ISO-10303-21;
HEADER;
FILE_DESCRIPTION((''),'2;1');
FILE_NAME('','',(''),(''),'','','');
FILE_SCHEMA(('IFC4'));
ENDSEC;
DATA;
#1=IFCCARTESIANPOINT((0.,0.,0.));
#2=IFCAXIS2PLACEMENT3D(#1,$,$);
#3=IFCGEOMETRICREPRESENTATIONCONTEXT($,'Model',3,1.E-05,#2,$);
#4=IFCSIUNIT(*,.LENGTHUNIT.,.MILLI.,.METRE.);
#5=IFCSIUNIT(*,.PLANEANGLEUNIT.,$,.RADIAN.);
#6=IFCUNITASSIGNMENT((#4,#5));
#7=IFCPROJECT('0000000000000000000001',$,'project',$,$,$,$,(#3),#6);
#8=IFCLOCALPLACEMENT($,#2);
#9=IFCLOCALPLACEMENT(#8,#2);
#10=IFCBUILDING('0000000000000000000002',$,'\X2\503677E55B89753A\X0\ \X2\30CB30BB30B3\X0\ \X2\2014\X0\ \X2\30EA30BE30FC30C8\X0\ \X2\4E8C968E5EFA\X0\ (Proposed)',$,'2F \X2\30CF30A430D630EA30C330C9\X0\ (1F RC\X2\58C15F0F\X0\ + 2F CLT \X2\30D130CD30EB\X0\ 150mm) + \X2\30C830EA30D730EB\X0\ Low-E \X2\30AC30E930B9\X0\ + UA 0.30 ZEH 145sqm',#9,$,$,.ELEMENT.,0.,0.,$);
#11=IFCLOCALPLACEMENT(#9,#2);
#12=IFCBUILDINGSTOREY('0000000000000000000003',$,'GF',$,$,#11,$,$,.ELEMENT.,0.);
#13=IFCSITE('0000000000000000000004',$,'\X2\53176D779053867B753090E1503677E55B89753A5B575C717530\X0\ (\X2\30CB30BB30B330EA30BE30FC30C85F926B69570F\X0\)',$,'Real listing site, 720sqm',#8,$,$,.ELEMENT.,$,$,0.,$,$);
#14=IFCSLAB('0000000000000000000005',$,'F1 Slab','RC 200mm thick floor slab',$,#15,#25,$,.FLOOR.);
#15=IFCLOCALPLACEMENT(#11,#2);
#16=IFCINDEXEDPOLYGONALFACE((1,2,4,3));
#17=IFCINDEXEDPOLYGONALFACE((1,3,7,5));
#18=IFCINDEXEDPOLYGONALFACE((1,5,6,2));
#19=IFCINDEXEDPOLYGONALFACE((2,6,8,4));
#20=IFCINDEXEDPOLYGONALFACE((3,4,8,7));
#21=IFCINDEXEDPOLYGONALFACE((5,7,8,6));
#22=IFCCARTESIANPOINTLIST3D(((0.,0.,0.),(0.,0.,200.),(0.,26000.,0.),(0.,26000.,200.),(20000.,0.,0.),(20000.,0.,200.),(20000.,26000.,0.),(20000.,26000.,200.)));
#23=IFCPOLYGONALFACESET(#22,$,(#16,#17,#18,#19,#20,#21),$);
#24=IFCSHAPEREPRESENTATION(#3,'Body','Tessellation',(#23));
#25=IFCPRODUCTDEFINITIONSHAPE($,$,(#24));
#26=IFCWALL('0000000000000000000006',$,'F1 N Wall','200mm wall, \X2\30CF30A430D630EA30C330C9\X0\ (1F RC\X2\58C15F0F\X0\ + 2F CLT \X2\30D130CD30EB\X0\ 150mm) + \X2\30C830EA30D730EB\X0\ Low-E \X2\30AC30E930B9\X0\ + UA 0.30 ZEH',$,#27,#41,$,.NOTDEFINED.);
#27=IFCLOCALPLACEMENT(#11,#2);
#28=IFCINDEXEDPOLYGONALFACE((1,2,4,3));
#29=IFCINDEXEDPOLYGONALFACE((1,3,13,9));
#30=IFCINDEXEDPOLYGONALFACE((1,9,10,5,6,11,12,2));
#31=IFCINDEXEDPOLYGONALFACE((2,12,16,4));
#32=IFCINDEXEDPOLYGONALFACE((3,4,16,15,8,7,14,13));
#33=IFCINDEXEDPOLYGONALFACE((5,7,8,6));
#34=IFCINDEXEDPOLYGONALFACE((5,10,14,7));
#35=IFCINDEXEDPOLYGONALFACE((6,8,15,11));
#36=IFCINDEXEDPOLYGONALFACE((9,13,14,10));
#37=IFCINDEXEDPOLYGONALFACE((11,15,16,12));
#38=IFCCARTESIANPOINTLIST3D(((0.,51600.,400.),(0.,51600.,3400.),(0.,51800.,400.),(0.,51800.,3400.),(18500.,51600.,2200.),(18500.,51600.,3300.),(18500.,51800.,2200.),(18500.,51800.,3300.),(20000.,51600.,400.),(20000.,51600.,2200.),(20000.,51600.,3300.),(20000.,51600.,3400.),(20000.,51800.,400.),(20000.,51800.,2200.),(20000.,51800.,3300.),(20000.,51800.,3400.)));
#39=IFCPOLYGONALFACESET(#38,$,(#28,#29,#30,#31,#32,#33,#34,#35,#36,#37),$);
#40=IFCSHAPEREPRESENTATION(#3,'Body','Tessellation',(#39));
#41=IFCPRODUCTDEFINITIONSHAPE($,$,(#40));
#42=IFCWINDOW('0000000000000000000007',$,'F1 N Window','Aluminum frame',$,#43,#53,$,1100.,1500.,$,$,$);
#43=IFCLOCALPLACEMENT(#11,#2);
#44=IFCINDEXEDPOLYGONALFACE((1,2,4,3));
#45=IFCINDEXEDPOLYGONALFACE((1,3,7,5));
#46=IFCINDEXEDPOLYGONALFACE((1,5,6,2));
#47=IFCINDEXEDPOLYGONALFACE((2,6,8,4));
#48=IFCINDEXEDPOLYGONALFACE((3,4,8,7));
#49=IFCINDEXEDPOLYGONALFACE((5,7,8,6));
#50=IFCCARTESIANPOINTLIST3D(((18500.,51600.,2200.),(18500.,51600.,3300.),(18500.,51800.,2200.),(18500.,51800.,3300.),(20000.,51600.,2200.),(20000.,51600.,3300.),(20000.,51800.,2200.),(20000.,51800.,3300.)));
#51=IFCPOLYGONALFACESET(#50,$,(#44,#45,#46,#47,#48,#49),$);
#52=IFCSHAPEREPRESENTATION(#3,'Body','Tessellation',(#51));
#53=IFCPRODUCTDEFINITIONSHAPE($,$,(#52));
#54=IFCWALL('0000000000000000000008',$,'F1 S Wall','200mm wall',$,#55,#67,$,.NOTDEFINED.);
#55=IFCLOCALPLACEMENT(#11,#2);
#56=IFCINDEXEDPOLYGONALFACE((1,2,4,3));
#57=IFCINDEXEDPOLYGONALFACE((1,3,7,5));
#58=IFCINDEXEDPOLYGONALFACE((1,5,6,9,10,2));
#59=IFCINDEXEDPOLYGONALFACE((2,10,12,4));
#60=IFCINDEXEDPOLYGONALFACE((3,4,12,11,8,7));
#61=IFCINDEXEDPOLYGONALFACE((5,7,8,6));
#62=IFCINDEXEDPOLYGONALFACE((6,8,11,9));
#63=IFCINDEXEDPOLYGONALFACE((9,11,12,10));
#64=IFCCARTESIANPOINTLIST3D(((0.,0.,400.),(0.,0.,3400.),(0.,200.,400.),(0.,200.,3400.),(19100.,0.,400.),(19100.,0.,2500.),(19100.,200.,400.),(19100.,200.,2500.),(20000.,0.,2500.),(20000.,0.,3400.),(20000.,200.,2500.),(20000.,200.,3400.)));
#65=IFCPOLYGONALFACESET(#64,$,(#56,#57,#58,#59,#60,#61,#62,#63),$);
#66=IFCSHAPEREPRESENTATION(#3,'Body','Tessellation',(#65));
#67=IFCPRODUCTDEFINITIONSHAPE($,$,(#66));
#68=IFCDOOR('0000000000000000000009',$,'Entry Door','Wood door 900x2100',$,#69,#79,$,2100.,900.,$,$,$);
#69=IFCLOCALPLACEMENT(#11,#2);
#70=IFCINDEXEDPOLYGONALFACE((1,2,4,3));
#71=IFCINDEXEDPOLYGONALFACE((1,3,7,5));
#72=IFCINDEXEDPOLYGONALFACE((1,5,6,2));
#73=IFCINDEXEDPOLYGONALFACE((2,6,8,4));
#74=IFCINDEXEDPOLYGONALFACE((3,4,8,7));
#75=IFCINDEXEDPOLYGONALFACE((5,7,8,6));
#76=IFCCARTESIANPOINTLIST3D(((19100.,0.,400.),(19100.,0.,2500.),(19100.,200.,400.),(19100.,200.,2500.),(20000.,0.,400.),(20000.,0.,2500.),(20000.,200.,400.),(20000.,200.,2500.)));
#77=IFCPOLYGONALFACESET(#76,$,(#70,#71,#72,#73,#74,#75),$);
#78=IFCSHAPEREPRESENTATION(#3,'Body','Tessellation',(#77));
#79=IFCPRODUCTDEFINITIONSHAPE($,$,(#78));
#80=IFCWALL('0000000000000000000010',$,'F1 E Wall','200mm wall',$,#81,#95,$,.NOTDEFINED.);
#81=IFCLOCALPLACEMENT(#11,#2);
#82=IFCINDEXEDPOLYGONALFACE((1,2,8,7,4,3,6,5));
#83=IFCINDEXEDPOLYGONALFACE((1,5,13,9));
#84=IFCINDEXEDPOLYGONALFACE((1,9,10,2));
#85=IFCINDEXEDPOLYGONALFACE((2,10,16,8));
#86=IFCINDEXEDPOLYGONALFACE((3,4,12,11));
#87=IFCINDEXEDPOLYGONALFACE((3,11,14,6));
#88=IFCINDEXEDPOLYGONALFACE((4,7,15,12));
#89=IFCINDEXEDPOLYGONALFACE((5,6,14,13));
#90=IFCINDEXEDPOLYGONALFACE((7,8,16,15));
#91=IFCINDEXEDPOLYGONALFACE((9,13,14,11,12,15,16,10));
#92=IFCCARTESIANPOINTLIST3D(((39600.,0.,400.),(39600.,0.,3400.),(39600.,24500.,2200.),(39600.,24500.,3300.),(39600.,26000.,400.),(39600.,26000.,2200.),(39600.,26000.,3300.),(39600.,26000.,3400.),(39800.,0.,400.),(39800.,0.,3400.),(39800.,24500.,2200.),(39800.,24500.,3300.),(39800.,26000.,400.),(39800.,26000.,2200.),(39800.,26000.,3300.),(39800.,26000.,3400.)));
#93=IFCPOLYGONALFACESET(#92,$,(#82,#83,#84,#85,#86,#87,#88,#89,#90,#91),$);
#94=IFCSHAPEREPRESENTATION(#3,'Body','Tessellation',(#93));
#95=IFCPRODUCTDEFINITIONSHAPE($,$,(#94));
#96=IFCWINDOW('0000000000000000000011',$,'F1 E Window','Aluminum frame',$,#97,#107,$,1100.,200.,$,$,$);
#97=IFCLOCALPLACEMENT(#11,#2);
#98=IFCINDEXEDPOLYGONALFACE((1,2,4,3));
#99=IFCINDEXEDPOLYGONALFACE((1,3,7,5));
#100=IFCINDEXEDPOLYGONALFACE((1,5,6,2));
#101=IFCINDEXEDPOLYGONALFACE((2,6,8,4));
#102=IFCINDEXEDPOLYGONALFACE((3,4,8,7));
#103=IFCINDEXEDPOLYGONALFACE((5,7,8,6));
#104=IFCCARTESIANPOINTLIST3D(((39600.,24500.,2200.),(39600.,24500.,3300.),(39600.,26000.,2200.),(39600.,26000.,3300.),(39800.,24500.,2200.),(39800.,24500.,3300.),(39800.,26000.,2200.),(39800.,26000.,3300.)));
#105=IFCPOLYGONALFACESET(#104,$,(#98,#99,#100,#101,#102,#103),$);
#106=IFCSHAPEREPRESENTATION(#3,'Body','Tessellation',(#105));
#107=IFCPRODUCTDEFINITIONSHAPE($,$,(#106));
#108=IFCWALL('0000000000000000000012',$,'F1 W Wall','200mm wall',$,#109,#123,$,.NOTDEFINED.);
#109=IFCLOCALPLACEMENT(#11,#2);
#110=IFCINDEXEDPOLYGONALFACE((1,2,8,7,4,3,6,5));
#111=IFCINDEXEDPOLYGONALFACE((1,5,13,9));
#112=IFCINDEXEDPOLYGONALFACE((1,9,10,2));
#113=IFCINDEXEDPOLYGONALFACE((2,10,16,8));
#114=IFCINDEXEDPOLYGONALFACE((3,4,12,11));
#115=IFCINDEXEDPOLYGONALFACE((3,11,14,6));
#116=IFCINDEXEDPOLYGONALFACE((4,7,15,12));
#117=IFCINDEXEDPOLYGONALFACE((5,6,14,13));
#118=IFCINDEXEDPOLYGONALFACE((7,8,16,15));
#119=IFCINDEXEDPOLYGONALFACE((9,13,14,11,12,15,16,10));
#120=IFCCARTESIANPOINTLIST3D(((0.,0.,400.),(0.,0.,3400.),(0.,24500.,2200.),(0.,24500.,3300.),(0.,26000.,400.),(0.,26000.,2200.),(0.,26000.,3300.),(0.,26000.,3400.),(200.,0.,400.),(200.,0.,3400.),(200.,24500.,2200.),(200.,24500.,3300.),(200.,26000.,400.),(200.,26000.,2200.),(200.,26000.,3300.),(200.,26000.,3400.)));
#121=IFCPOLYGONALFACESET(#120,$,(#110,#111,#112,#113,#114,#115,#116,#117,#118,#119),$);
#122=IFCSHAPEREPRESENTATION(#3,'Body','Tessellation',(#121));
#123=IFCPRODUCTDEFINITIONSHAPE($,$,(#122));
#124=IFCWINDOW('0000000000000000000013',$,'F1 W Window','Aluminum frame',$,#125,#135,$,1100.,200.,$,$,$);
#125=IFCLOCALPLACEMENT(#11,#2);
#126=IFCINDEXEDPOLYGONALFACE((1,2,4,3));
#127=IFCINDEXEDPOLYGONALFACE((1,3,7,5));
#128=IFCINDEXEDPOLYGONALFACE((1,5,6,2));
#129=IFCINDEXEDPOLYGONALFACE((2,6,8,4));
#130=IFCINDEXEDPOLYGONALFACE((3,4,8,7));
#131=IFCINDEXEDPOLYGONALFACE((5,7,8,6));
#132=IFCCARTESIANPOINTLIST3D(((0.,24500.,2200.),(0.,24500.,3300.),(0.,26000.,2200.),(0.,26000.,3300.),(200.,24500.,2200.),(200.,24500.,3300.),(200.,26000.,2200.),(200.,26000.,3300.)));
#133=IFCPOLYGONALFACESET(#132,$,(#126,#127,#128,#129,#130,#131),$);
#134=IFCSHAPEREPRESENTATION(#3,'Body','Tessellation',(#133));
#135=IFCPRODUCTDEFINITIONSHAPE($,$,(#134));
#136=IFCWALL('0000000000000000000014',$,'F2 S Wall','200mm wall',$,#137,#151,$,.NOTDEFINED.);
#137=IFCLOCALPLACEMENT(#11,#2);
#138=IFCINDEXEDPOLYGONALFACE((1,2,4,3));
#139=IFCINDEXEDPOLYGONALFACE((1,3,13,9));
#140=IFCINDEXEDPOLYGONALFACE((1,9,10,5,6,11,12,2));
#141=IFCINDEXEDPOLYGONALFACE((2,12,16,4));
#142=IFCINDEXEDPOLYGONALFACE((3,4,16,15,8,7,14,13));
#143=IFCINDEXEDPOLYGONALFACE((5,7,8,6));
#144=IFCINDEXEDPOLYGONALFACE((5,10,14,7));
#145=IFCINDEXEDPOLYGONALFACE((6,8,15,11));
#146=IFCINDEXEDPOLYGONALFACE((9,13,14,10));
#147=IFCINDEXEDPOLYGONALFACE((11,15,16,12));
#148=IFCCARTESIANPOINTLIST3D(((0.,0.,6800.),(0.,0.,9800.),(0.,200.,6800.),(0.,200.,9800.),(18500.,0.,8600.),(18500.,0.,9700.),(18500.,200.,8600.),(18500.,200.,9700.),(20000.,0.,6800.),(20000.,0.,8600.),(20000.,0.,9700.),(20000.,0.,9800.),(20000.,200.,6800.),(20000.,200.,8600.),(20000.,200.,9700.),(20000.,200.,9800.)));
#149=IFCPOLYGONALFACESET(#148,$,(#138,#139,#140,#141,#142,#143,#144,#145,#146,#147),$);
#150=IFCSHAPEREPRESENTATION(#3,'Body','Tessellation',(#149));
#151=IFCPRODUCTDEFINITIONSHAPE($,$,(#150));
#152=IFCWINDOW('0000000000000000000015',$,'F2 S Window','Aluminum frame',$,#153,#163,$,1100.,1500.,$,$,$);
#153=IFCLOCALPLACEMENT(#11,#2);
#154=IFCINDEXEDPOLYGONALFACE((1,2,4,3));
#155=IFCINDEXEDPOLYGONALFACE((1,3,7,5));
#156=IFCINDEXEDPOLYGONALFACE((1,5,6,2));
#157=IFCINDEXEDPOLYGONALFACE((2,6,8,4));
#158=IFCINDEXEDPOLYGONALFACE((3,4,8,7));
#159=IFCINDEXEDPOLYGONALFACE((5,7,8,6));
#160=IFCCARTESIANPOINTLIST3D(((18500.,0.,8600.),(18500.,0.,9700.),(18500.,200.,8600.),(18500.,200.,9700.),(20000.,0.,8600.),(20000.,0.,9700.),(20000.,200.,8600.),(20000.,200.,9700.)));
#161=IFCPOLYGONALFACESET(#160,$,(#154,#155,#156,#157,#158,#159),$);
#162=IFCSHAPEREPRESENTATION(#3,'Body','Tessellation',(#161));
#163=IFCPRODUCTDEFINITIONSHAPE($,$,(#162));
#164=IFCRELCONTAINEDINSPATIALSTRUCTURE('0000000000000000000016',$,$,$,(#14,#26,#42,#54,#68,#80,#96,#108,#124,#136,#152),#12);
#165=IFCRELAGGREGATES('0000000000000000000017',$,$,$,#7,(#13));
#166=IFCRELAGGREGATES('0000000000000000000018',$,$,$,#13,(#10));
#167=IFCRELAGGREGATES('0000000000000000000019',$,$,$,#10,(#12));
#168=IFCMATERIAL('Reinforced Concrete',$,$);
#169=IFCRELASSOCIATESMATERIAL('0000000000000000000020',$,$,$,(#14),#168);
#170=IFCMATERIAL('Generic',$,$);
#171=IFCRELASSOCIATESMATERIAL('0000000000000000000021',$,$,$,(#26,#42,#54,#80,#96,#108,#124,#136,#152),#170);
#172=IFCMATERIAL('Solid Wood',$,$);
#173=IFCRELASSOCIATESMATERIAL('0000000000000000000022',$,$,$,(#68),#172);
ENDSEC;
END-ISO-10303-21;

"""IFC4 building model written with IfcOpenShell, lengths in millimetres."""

from ifc_helpers import new_model, si_unit, frame, frame_2d, origin, place, context, project, spatial, rectangle, extrude, material, element, fill, save


model = new_model("IFC4")

# Units and contexts
model_context = context("Model", 3, precision=1e-05, world=origin())
ifc_project = project(units=[si_unit("LENGTHUNIT", "METRE", prefix="MILLI"), si_unit("PLANEANGLEUNIT", "RADIAN")], contexts=[model_context])

# Site, building, storey
site_placement = place(None, origin())
site = spatial("IfcSite", under=ifc_project, at=site_placement, Name="北海道虻田郡倶知安町字山田 (ニセコリゾート徒歩圏)", ObjectType="Real listing site, 720sqm", CompositionType="ELEMENT", RefElevation=0.0)
building_placement = place(site_placement, origin())
building = spatial("IfcBuilding", under=site, at=building_placement, Name="倶知安町 ニセコ — リゾート 二階建 (Proposed)", ObjectType="2F ハイブリッド (1F RC壁式 + 2F CLT パネル 150mm) + トリプル Low-E ガラス + UA 0.30 ZEH 145sqm", CompositionType="ELEMENT", ElevationOfRefHeight=0.0, ElevationOfTerrain=0.0)
storey_placement = place(building_placement, origin())
storey = spatial("IfcBuildingStorey", under=building, at=storey_placement, Name="GF", CompositionType="ELEMENT", Elevation=0.0)

# Slab
ifc_material_1 = material(Name="Reinforced Concrete")
slab_1_placement = place(storey_placement, origin())
element("IfcSlab", 1, at=slab_1_placement, inside=storey, material=ifc_material_1, Name="F1 Slab", Description="RC 200mm thick floor slab", PredefinedType="FLOOR", context=model_context, shape_type="SweptSolid", body=[
    extrude(rectangle(XDim=20000.0, YDim=26000.0, at=frame_2d((10000.0, 13000.0))), origin(), (0.0, 0.0, 1.0), 200.0),
])

# Wall, opening, window
ifc_material_2 = material(Name="Generic")
wall_1_placement = place(storey_placement, frame((0.0, 25800.0, 200.0)))
wall_1 = element("IfcWall", 2, at=wall_1_placement, inside=storey, material=ifc_material_2, Name="F1 N Wall", Description="200mm wall, ハイブリッド (1F RC壁式 + 2F CLT パネル 150mm) + トリプル Low-E ガラス + UA 0.30 ZEH", PredefinedType="NOTDEFINED", context=model_context, shape_type="SweptSolid", body=[
    extrude(rectangle(XDim=20000.0, YDim=200.0, at=frame_2d((10000.0, 100.0))), frame((0.0, 25800.0, 200.0)), (0.0, 0.0, 1.0), 3000.0),
])
opening_1_placement = place(storey_placement, frame((9250.0, 25800.0, 1100.0)))
opening_1 = element("IfcOpeningElement", 3, at=opening_1_placement, cuts=wall_1, PredefinedType="NOTDEFINED", context=model_context, shape_type="SweptSolid", body=[
    extrude(rectangle(XDim=1500.0, YDim=200.0, at=frame_2d((750.0, 100.0))), frame((9250.0, 25800.0, 1100.0)), (0.0, 0.0, 1.0), 1100.0),
])
window_1_placement = place(storey_placement, frame((9250.0, 25800.0, 1100.0)))
window_1 = element("IfcWindow", 4, at=window_1_placement, inside=storey, material=ifc_material_2, Name="F1 N Window", Description="Aluminum frame", OverallHeight=1100.0, OverallWidth=1500.0, context=model_context, shape_type="SweptSolid", body=[
    extrude(rectangle(XDim=1500.0, YDim=200.0, at=frame_2d((750.0, 100.0))), frame((9250.0, 25800.0, 1100.0)), (0.0, 0.0, 1.0), 1100.0),
])
fill(opening_1, window_1)

# Wall, opening, door
wall_2_placement = place(storey_placement, frame((0.0, 0.0, 200.0)))
wall_2 = element("IfcWall", 5, at=wall_2_placement, inside=storey, material=ifc_material_2, Name="F1 S Wall", Description="200mm wall", PredefinedType="NOTDEFINED", context=model_context, shape_type="SweptSolid", body=[
    extrude(rectangle(XDim=20000.0, YDim=200.0, at=frame_2d((10000.0, 100.0))), frame((0.0, 0.0, 200.0)), (0.0, 0.0, 1.0), 3000.0),
])
opening_2_placement = place(storey_placement, frame((9550.0, 0.0, 200.0)))
opening_2 = element("IfcOpeningElement", 6, at=opening_2_placement, cuts=wall_2, PredefinedType="NOTDEFINED", context=model_context, shape_type="SweptSolid", body=[
    extrude(rectangle(XDim=900.0, YDim=200.0, at=frame_2d((450.0, 100.0))), frame((9550.0, 0.0, 200.0)), (0.0, 0.0, 1.0), 2100.0),
])
ifc_material_3 = material(Name="Solid Wood")
door_placement = place(storey_placement, frame((9550.0, 0.0, 200.0)))
door = element("IfcDoor", 7, at=door_placement, inside=storey, material=ifc_material_3, Name="Entry Door", Description="Wood door 900x2100", OverallHeight=2100.0, OverallWidth=900.0, context=model_context, shape_type="SweptSolid", body=[
    extrude(rectangle(XDim=900.0, YDim=200.0, at=frame_2d((450.0, 100.0))), frame((9550.0, 0.0, 200.0)), (0.0, 0.0, 1.0), 2100.0),
])
fill(opening_2, door)

# Walls, openings, windows
wall_3_placement = place(storey_placement, frame((19800.0, 0.0, 200.0)))
wall_3 = element("IfcWall", 8, at=wall_3_placement, inside=storey, material=ifc_material_2, Name="F1 E Wall", Description="200mm wall", PredefinedType="NOTDEFINED", context=model_context, shape_type="SweptSolid", body=[
    extrude(rectangle(XDim=200.0, YDim=26000.0, at=frame_2d((100.0, 13000.0))), frame((19800.0, 0.0, 200.0)), (0.0, 0.0, 1.0), 3000.0),
])
opening_3_placement = place(storey_placement, frame((19800.0, 12250.0, 1100.0)))
opening_3 = element("IfcOpeningElement", 9, at=opening_3_placement, cuts=wall_3, PredefinedType="NOTDEFINED", context=model_context, shape_type="SweptSolid", body=[
    extrude(rectangle(XDim=200.0, YDim=1500.0, at=frame_2d((100.0, 750.0))), frame((19800.0, 12250.0, 1100.0)), (0.0, 0.0, 1.0), 1100.0),
])
window_2_placement = place(storey_placement, frame((19800.0, 12250.0, 1100.0)))
window_2 = element("IfcWindow", 10, at=window_2_placement, inside=storey, material=ifc_material_2, Name="F1 E Window", Description="Aluminum frame", OverallHeight=1100.0, OverallWidth=200.0, context=model_context, shape_type="SweptSolid", body=[
    extrude(rectangle(XDim=200.0, YDim=1500.0, at=frame_2d((100.0, 750.0))), frame((19800.0, 12250.0, 1100.0)), (0.0, 0.0, 1.0), 1100.0),
])
fill(opening_3, window_2)
wall_4_placement = place(storey_placement, frame((0.0, 0.0, 200.0)))
wall_4 = element("IfcWall", 11, at=wall_4_placement, inside=storey, material=ifc_material_2, Name="F1 W Wall", Description="200mm wall", PredefinedType="NOTDEFINED", context=model_context, shape_type="SweptSolid", body=[
    extrude(rectangle(XDim=200.0, YDim=26000.0, at=frame_2d((100.0, 13000.0))), frame((0.0, 0.0, 200.0)), (0.0, 0.0, 1.0), 3000.0),
])
opening_4_placement = place(storey_placement, frame((0.0, 12250.0, 1100.0)))
opening_4 = element("IfcOpeningElement", 12, at=opening_4_placement, cuts=wall_4, PredefinedType="NOTDEFINED", context=model_context, shape_type="SweptSolid", body=[
    extrude(rectangle(XDim=200.0, YDim=1500.0, at=frame_2d((100.0, 750.0))), frame((0.0, 12250.0, 1100.0)), (0.0, 0.0, 1.0), 1100.0),
])
window_3_placement = place(storey_placement, frame((0.0, 12250.0, 1100.0)))
window_3 = element("IfcWindow", 13, at=window_3_placement, inside=storey, material=ifc_material_2, Name="F1 W Window", Description="Aluminum frame", OverallHeight=1100.0, OverallWidth=200.0, context=model_context, shape_type="SweptSolid", body=[
    extrude(rectangle(XDim=200.0, YDim=1500.0, at=frame_2d((100.0, 750.0))), frame((0.0, 12250.0, 1100.0)), (0.0, 0.0, 1.0), 1100.0),
])
fill(opening_4, window_3)
wall_5_placement = place(storey_placement, frame((0.0, 0.0, 3400.0)))
wall_5 = element("IfcWall", 14, at=wall_5_placement, inside=storey, material=ifc_material_2, Name="F2 S Wall", Description="200mm wall", PredefinedType="NOTDEFINED", context=model_context, shape_type="SweptSolid", body=[
    extrude(rectangle(XDim=20000.0, YDim=200.0, at=frame_2d((10000.0, 100.0))), frame((0.0, 0.0, 3400.0)), (0.0, 0.0, 1.0), 3000.0),
])
opening_5_placement = place(storey_placement, frame((9250.0, 0.0, 4300.0)))
opening_5 = element("IfcOpeningElement", 15, at=opening_5_placement, cuts=wall_5, PredefinedType="NOTDEFINED", context=model_context, shape_type="SweptSolid", body=[
    extrude(rectangle(XDim=1500.0, YDim=200.0, at=frame_2d((750.0, 100.0))), frame((9250.0, 0.0, 4300.0)), (0.0, 0.0, 1.0), 1100.0),
])
window_4_placement = place(storey_placement, frame((9250.0, 0.0, 4300.0)))
window_4 = element("IfcWindow", 16, at=window_4_placement, inside=storey, material=ifc_material_2, Name="F2 S Window", Description="Aluminum frame", OverallHeight=1100.0, OverallWidth=1500.0, context=model_context, shape_type="SweptSolid", body=[
    extrude(rectangle(XDim=1500.0, YDim=200.0, at=frame_2d((750.0, 100.0))), frame((9250.0, 0.0, 4300.0)), (0.0, 0.0, 1.0), 1100.0),
])
fill(opening_5, window_4)

save(model, "model.ifc")
